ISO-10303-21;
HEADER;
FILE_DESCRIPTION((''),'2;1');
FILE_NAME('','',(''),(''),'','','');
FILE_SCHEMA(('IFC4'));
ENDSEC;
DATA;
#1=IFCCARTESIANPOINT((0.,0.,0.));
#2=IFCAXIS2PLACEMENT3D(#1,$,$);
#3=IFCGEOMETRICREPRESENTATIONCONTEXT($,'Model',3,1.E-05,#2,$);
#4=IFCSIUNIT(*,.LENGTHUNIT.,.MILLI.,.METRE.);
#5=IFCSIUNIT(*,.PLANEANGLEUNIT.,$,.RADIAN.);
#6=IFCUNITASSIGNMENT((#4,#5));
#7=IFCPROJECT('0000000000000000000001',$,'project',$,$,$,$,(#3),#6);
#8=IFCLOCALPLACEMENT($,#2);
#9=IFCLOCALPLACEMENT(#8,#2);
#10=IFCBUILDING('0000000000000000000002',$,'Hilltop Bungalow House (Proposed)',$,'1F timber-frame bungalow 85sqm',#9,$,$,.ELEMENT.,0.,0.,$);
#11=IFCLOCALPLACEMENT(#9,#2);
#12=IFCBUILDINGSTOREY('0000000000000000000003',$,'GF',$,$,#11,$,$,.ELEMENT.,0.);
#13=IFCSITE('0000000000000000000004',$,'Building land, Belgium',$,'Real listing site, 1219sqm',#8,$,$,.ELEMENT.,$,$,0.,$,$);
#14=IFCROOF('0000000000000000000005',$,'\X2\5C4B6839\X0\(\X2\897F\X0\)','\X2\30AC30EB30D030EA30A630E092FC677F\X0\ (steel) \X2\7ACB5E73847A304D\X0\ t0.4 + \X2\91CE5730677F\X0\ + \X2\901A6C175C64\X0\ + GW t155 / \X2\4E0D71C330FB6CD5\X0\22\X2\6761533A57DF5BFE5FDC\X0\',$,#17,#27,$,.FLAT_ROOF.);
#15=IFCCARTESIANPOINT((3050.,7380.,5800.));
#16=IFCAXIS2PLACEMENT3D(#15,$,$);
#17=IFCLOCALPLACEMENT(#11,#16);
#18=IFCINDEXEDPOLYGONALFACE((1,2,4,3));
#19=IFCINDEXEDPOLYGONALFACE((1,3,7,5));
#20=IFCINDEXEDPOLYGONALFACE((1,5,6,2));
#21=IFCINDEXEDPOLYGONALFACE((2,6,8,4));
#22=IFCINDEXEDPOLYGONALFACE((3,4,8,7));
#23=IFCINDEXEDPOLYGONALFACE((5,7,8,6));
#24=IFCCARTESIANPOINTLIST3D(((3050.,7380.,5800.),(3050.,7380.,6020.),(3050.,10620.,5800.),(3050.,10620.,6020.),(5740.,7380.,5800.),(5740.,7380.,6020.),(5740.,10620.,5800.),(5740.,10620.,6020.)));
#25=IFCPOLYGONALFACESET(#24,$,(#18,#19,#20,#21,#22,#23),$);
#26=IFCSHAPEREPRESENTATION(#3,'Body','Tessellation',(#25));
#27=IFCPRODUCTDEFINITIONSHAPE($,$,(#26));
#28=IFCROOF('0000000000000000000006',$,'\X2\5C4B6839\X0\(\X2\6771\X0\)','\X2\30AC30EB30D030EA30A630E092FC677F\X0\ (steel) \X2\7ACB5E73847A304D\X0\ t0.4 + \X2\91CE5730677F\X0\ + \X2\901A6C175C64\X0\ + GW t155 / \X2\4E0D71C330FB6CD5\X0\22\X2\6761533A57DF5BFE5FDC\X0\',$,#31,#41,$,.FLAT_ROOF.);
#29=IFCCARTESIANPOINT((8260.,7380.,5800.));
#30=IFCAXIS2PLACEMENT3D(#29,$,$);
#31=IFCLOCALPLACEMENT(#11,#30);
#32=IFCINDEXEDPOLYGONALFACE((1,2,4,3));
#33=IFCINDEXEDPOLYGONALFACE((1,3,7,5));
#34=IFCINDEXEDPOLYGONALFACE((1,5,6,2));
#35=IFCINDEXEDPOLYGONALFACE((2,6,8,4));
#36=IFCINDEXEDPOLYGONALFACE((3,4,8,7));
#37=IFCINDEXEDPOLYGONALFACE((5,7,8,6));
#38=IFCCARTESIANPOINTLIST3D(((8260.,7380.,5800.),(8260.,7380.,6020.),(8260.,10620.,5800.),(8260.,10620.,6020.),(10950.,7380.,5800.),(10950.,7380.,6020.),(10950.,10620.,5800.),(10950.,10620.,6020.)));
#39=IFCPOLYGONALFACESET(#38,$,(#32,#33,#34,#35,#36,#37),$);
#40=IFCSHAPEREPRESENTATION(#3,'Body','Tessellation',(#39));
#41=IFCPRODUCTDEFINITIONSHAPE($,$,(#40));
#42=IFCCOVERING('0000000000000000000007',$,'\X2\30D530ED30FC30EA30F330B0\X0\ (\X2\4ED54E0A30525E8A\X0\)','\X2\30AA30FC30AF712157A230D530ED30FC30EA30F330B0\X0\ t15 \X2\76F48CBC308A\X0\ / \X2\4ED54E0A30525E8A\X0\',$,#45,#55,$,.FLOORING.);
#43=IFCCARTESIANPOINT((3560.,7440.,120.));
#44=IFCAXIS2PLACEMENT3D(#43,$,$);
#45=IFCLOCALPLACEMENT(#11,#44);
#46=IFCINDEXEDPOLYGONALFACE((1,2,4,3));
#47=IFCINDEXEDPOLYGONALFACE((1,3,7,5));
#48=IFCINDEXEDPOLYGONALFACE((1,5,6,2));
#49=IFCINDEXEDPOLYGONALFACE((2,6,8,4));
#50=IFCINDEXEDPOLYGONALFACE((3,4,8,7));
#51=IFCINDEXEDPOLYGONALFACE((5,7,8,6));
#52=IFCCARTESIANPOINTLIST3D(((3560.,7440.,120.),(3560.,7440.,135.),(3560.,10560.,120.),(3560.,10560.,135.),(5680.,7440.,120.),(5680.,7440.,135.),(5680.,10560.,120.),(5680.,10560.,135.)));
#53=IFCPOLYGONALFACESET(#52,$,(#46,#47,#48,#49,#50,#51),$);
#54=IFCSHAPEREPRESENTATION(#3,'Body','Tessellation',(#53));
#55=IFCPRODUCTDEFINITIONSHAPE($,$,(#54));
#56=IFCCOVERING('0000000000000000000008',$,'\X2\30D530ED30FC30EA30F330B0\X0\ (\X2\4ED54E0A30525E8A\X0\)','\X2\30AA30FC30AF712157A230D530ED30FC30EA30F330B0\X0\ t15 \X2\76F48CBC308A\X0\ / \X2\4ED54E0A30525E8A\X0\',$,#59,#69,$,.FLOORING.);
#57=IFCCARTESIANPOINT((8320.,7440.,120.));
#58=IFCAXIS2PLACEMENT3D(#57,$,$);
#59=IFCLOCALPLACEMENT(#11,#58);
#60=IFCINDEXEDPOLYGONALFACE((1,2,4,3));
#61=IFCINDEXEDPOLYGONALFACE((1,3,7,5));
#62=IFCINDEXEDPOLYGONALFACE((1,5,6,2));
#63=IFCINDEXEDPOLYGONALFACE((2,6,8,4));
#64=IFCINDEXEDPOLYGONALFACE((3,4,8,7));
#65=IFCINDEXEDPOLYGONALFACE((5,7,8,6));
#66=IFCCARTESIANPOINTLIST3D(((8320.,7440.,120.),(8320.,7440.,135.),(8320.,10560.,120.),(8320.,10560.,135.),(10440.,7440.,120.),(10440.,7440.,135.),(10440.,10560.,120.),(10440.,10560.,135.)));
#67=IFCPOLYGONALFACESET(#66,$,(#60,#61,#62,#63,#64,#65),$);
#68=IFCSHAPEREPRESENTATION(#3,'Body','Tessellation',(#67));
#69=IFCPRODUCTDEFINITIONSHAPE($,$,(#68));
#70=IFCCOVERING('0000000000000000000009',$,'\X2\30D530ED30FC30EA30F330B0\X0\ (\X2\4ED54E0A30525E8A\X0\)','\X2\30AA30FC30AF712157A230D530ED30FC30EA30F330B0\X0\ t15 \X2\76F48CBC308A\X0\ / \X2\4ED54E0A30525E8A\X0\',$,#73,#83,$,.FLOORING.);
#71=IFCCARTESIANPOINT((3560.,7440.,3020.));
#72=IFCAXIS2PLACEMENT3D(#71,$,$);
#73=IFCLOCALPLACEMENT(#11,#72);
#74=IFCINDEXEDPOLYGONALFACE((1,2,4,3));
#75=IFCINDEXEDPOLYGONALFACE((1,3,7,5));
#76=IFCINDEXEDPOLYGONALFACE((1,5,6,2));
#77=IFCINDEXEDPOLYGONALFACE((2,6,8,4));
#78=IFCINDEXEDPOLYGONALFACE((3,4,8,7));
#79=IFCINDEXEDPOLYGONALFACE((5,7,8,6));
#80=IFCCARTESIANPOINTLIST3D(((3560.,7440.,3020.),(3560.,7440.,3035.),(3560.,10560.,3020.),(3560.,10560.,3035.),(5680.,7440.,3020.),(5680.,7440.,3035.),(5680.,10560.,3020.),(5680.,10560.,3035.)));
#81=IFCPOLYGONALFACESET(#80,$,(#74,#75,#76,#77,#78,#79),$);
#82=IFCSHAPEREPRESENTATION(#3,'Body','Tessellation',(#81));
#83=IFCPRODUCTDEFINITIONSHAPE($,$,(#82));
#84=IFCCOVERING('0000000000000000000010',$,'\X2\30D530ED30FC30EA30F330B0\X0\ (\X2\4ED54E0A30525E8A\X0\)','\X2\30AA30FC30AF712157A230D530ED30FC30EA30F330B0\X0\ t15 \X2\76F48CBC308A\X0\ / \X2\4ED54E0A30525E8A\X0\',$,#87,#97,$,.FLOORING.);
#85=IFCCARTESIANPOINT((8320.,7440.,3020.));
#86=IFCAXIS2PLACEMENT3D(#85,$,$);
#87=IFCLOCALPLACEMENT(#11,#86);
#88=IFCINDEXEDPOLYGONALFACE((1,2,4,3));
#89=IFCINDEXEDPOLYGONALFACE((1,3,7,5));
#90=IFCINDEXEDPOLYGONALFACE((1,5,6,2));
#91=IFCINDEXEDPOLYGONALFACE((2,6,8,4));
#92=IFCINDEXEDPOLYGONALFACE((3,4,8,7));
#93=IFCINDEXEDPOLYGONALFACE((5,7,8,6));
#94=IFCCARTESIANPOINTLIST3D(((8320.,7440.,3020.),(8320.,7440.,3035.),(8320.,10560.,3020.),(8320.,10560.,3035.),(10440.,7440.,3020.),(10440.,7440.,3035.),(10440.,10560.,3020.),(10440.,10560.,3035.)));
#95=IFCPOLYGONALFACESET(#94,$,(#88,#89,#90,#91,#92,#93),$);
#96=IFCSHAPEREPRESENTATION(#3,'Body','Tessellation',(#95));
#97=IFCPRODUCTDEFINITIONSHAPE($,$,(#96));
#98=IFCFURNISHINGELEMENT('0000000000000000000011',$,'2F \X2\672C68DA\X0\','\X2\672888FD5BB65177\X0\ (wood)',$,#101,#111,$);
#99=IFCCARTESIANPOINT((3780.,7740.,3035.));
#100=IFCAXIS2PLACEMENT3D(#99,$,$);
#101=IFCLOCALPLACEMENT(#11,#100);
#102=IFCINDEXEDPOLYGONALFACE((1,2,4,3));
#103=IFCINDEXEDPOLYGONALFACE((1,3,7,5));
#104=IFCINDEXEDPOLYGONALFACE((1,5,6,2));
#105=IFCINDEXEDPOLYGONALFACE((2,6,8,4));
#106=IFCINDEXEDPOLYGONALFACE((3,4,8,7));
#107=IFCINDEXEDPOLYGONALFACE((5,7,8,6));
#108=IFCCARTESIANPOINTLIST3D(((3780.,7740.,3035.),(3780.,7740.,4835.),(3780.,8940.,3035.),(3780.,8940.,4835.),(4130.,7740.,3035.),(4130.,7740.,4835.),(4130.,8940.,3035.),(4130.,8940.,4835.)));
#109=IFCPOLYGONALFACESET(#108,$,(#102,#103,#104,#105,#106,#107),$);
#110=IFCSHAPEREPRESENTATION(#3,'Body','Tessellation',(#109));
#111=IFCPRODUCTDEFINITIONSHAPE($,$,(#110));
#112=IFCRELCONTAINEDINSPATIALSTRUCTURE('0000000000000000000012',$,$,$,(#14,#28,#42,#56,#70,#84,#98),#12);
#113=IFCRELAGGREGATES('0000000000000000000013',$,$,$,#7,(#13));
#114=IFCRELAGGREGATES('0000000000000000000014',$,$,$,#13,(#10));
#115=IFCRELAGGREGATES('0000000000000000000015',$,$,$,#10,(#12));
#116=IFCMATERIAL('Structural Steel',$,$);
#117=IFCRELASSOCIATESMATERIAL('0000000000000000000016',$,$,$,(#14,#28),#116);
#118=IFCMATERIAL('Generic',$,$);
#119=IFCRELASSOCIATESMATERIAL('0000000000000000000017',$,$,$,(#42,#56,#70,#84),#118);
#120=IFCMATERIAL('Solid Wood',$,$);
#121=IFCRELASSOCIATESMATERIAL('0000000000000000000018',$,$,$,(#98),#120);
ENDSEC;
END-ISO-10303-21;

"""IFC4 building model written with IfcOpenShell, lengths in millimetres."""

from ifc_helpers import new_model, si_unit, frame, frame_2d, origin, place, context, project, spatial, rectangle, extrude, material, element, save


model = new_model("IFC4")

# Units and contexts
model_context = context("Model", 3, precision=1e-05, world=origin())
ifc_project = project(units=[si_unit("LENGTHUNIT", "METRE", prefix="MILLI"), si_unit("PLANEANGLEUNIT", "RADIAN")], contexts=[model_context])

# Site, building, storey
site_placement = place(None, origin())
site = spatial("IfcSite", under=ifc_project, at=site_placement, Name="Building land, Belgium", ObjectType="Real listing site, 1219sqm", CompositionType="ELEMENT", RefElevation=0.0)
building_placement = place(site_placement, origin())
building = spatial("IfcBuilding", under=site, at=building_placement, Name="Hilltop Bungalow House (Proposed)", ObjectType="1F timber-frame bungalow 85sqm", CompositionType="ELEMENT", ElevationOfRefHeight=0.0, ElevationOfTerrain=0.0)
storey_placement = place(building_placement, origin())
storey = spatial("IfcBuildingStorey", under=building, at=storey_placement, Name="GF", CompositionType="ELEMENT", Elevation=0.0)

# Shared definitions
ifc_material_1 = material(Name="Solid Wood")

# Shared definitions
ifc_material_2 = material(Name="Generic")

# Roofs
ifc_material_3 = material(Name="Structural Steel")
roof_1_placement = place(storey_placement, frame((3050.0, 7380.0, 5800.0)))
element("IfcRoof", 1, at=roof_1_placement, inside=storey, material=ifc_material_3, Name="屋根(西)", Description="ガルバリウム鋼板 (steel) 立平葺き t0.4 + 野地板 + 通気層 + GW t155 / 不燃・法22条区域対応", PredefinedType="FLAT_ROOF", context=model_context, shape_type="SweptSolid", body=[
    extrude(rectangle(XDim=2690.0, YDim=3240.0, at=frame_2d((1345.0, 1620.0))), frame((3050.0, 7380.0, 5800.0)), (0.0, 0.0, 1.0), 220.0),
])
roof_2_placement = place(storey_placement, frame((8260.0, 7380.0, 5800.0)))
element("IfcRoof", 2, at=roof_2_placement, inside=storey, material=ifc_material_3, Name="屋根(東)", Description="ガルバリウム鋼板 (steel) 立平葺き t0.4 + 野地板 + 通気層 + GW t155 / 不燃・法22条区域対応", PredefinedType="FLAT_ROOF", context=model_context, shape_type="SweptSolid", body=[
    extrude(rectangle(XDim=2690.0, YDim=3240.0, at=frame_2d((1345.0, 1620.0))), frame((8260.0, 7380.0, 5800.0)), (0.0, 0.0, 1.0), 220.0),
])

# Coverings
covering_1_placement = place(storey_placement, frame((3560.0, 7440.0, 120.0)))
element("IfcCovering", 3, at=covering_1_placement, inside=storey, material=ifc_material_2, Name="フローリング (仕上げ床)", Description="オーク無垢フローリング t15 直貼り / 仕上げ床", PredefinedType="FLOORING", context=model_context, shape_type="SweptSolid", body=[
    extrude(rectangle(XDim=2120.0, YDim=3120.0, at=frame_2d((1060.0, 1560.0))), frame((3560.0, 7440.0, 120.0)), (0.0, 0.0, 1.0), 15.0),
])
covering_2_placement = place(storey_placement, frame((8320.0, 7440.0, 120.0)))
element("IfcCovering", 4, at=covering_2_placement, inside=storey, material=ifc_material_2, Name="フローリング (仕上げ床)", Description="オーク無垢フローリング t15 直貼り / 仕上げ床", PredefinedType="FLOORING", context=model_context, shape_type="SweptSolid", body=[
    extrude(rectangle(XDim=2120.0, YDim=3120.0, at=frame_2d((1060.0, 1560.0))), frame((8320.0, 7440.0, 120.0)), (0.0, 0.0, 1.0), 15.0),
])
covering_3_placement = place(storey_placement, frame((3560.0, 7440.0, 3020.0)))
element("IfcCovering", 5, at=covering_3_placement, inside=storey, material=ifc_material_2, Name="フローリング (仕上げ床)", Description="オーク無垢フローリング t15 直貼り / 仕上げ床", PredefinedType="FLOORING", context=model_context, shape_type="SweptSolid", body=[
    extrude(rectangle(XDim=2120.0, YDim=3120.0, at=frame_2d((1060.0, 1560.0))), frame((3560.0, 7440.0, 3020.0)), (0.0, 0.0, 1.0), 15.0),
])
covering_4_placement = place(storey_placement, frame((8320.0, 7440.0, 3020.0)))
element("IfcCovering", 6, at=covering_4_placement, inside=storey, material=ifc_material_2, Name="フローリング (仕上げ床)", Description="オーク無垢フローリング t15 直貼り / 仕上げ床", PredefinedType="FLOORING", context=model_context, shape_type="SweptSolid", body=[
    extrude(rectangle(XDim=2120.0, YDim=3120.0, at=frame_2d((1060.0, 1560.0))), frame((8320.0, 7440.0, 3020.0)), (0.0, 0.0, 1.0), 15.0),
])

# Furnishing element
furnishing_placement = place(storey_placement, frame((3780.0, 7740.0, 3035.0)))
element("IfcFurnishingElement", 7, at=furnishing_placement, inside=storey, material=ifc_material_1, Name="2F 本棚", Description="木製家具 (wood)", context=model_context, shape_type="SweptSolid", body=[
    extrude(rectangle(XDim=350.0, YDim=1200.0, at=frame_2d((175.0, 600.0))), frame((3780.0, 7740.0, 3035.0)), (0.0, 0.0, 1.0), 1800.0),
])

save(model, "model.ifc")
